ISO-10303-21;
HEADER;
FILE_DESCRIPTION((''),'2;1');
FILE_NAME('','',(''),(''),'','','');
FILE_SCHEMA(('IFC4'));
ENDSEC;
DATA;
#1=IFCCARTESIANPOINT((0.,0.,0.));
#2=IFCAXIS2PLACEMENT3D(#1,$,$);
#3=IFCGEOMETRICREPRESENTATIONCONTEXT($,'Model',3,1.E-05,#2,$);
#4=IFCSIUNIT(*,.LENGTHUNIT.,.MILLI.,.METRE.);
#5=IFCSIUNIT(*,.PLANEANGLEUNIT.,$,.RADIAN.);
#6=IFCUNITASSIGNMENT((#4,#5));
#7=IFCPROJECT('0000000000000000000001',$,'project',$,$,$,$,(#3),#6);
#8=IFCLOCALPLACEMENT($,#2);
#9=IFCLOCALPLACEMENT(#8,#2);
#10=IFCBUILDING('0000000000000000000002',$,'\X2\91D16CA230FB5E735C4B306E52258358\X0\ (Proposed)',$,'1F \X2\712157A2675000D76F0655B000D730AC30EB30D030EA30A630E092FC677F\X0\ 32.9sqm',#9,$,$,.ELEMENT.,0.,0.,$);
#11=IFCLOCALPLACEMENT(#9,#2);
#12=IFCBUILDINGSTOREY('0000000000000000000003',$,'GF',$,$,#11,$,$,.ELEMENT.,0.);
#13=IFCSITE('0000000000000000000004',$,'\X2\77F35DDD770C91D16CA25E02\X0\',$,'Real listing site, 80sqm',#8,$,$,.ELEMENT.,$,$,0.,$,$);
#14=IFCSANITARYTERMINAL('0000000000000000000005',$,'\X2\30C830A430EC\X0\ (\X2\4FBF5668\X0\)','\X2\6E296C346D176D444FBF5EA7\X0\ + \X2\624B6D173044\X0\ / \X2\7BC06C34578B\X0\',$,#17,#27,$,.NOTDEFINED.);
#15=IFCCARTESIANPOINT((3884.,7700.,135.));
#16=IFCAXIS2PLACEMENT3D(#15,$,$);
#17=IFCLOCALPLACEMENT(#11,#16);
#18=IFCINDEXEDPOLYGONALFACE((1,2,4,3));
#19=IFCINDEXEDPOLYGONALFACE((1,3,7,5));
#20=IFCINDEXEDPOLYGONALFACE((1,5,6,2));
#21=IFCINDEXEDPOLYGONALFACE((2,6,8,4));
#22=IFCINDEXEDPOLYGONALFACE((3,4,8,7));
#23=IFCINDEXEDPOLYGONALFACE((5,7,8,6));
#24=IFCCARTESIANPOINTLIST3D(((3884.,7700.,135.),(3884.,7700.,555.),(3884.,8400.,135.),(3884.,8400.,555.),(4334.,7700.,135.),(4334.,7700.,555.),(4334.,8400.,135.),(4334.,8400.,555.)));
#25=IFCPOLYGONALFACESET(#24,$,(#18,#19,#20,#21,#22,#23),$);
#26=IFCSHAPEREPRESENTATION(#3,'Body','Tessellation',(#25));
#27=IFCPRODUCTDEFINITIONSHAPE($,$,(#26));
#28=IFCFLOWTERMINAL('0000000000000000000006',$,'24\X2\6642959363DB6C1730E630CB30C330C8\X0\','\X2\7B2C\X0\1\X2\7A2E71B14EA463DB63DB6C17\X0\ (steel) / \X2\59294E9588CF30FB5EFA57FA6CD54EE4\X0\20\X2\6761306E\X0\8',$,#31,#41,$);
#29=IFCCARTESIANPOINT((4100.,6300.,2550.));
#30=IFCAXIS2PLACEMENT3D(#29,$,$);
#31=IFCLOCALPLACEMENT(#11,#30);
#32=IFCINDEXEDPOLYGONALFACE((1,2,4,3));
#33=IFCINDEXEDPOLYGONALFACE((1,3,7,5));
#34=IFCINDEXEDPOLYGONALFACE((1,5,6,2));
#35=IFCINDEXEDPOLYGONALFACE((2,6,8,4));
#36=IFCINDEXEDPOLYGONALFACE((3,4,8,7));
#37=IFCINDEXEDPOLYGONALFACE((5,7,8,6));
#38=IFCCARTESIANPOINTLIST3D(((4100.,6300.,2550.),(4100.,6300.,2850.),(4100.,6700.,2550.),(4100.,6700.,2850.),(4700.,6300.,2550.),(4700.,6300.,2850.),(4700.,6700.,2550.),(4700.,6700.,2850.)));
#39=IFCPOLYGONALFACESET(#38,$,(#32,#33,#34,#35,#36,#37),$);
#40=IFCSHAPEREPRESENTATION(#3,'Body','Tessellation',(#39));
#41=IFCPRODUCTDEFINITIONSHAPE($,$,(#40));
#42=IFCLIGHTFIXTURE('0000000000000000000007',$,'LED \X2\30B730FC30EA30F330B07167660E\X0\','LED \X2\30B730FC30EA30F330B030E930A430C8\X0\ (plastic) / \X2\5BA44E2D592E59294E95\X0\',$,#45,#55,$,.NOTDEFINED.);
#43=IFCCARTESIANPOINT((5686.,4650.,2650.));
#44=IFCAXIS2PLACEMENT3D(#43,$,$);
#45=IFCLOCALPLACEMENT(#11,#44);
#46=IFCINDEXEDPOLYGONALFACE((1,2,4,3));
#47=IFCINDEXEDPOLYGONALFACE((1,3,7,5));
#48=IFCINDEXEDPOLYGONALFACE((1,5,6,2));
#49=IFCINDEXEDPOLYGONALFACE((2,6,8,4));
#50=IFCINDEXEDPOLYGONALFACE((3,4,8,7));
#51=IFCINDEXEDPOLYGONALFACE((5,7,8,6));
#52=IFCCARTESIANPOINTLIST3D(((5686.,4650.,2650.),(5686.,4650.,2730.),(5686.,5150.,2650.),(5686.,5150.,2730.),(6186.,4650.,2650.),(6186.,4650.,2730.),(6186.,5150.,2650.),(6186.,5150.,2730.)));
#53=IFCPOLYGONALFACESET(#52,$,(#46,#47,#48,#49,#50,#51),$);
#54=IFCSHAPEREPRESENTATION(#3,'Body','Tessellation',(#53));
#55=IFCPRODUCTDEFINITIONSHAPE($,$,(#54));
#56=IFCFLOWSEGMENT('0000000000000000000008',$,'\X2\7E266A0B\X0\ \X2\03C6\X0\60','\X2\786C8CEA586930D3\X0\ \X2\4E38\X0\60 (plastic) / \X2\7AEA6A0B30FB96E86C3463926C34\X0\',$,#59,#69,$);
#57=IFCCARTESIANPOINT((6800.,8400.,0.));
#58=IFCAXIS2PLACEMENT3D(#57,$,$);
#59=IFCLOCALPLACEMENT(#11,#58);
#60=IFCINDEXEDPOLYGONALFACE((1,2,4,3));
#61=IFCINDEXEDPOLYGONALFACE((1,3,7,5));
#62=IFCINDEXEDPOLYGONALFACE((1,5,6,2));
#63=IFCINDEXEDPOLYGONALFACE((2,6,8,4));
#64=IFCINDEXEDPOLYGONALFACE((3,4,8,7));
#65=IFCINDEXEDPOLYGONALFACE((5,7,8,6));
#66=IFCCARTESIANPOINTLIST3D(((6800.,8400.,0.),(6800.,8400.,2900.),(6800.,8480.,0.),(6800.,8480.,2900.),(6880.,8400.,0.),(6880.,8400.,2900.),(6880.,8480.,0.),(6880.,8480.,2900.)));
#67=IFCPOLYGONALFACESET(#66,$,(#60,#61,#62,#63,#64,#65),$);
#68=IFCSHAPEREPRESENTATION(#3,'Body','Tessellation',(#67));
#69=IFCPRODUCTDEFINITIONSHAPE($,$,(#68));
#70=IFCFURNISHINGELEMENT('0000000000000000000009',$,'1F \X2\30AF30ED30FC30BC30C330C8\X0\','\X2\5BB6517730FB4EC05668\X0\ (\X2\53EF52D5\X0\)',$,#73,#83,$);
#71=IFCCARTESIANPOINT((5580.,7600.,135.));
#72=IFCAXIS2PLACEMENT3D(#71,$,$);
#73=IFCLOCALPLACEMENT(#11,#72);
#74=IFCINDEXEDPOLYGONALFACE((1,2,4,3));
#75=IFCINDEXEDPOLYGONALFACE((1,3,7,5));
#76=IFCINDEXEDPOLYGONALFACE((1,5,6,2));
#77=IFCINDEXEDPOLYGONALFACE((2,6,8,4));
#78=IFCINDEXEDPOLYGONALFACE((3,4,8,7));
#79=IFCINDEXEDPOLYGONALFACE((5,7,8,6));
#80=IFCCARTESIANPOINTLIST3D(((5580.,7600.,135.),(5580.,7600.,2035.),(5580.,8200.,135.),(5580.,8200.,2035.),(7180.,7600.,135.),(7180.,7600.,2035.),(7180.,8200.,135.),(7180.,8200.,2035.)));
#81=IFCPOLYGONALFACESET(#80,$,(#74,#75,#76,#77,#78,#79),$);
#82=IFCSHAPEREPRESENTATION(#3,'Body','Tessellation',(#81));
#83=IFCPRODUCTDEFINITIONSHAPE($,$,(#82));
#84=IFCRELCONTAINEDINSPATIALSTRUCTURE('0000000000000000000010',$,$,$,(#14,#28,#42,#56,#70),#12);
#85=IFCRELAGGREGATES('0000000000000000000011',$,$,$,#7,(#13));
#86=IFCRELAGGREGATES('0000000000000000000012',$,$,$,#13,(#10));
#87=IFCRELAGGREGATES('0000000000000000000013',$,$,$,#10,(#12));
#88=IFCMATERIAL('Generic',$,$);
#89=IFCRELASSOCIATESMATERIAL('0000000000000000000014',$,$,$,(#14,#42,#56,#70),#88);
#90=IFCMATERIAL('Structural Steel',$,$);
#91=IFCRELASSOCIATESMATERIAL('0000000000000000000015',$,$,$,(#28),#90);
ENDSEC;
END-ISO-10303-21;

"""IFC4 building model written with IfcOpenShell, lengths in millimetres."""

from ifc_helpers import new_model, si_unit, frame, frame_2d, origin, place, context, project, spatial, rectangle, extrude, material, element, save


model = new_model("IFC4")

# Units and contexts
model_context = context("Model", 3, precision=1e-05, world=origin())
ifc_project = project(units=[si_unit("LENGTHUNIT", "METRE", prefix="MILLI"), si_unit("PLANEANGLEUNIT", "RADIAN")], contexts=[model_context])

# Site, building, storey
site_placement = place(None, origin())
site = spatial("IfcSite", under=ifc_project, at=site_placement, Name="石川県金沢市", ObjectType="Real listing site, 80sqm", CompositionType="ELEMENT", RefElevation=0.0)
building_placement = place(site_placement, origin())
building = spatial("IfcBuilding", under=site, at=building_placement, Name="金沢・平屋の別荘 (Proposed)", ObjectType="1F 無垢材×漆喰×ガルバリウム鋼板 32.9sqm", CompositionType="ELEMENT", ElevationOfRefHeight=0.0, ElevationOfTerrain=0.0)
storey_placement = place(building_placement, origin())
storey = spatial("IfcBuildingStorey", under=building, at=storey_placement, Name="GF", CompositionType="ELEMENT", Elevation=0.0)

# Shared definitions
ifc_material_1 = material(Name="Generic")

# Sanitary terminal
sanitary_terminal_placement = place(storey_placement, frame((3884.0, 7700.0, 135.0)))
element("IfcSanitaryTerminal", 1, at=sanitary_terminal_placement, inside=storey, material=ifc_material_1, Name="トイレ (便器)", Description="温水洗浄便座 + 手洗い / 節水型", PredefinedType="NOTDEFINED", context=model_context, shape_type="SweptSolid", body=[
    extrude(rectangle(XDim=450.0, YDim=700.0, at=frame_2d((225.0, 350.0))), frame((3884.0, 7700.0, 135.0)), (0.0, 0.0, 1.0), 420.0),
])

# Flow terminal
ifc_material_2 = material(Name="Structural Steel")
flow_terminal_placement = place(storey_placement, frame((4100.0, 6300.0, 2550.0)))
element("IfcFlowTerminal", 2, at=flow_terminal_placement, inside=storey, material=ifc_material_2, Name="24時間換気ユニット", Description="第1種熱交換換気 (steel) / 天井裏・建基法令20条の8", context=model_context, shape_type="SweptSolid", body=[
    extrude(rectangle(XDim=600.0, YDim=400.0, at=frame_2d((300.0, 200.0))), frame((4100.0, 6300.0, 2550.0)), (0.0, 0.0, 1.0), 300.0),
])

# Light fixture
light_fixture_placement = place(storey_placement, frame((5686.0, 4650.0, 2650.0)))
element("IfcLightFixture", 3, at=light_fixture_placement, inside=storey, material=ifc_material_1, Name="LED シーリング照明", Description="LED シーリングライト (plastic) / 室中央天井", PredefinedType="NOTDEFINED", context=model_context, shape_type="SweptSolid", body=[
    extrude(rectangle(XDim=500.0, YDim=500.0, at=frame_2d((250.0, 250.0))), frame((5686.0, 4650.0, 2650.0)), (0.0, 0.0, 1.0), 80.0),
])

# Flow segment
flow_segment_placement = place(storey_placement, frame((6800.0, 8400.0, 0.0)))
element("IfcFlowSegment", 4, at=flow_segment_placement, inside=storey, material=ifc_material_1, Name="縦樋 φ60", Description="硬質塩ビ 丸60 (plastic) / 竪樋・雨水排水", context=model_context, shape_type="SweptSolid", body=[
    extrude(rectangle(XDim=80.0, YDim=80.0, at=frame_2d((40.0, 40.0))), frame((6800.0, 8400.0, 0.0)), (0.0, 0.0, 1.0), 2900.0),
])

# Furnishing element
furnishing_placement = place(storey_placement, frame((5580.0, 7600.0, 135.0)))
element("IfcFurnishingElement", 5, at=furnishing_placement, inside=storey, material=ifc_material_1, Name="1F クローゼット", Description="家具・什器 (可動)", context=model_context, shape_type="SweptSolid", body=[
    extrude(rectangle(XDim=1600.0, YDim=600.0, at=frame_2d((800.0, 300.0))), frame((5580.0, 7600.0, 135.0)), (0.0, 0.0, 1.0), 1900.0),
])

save(model, "model.ifc")
